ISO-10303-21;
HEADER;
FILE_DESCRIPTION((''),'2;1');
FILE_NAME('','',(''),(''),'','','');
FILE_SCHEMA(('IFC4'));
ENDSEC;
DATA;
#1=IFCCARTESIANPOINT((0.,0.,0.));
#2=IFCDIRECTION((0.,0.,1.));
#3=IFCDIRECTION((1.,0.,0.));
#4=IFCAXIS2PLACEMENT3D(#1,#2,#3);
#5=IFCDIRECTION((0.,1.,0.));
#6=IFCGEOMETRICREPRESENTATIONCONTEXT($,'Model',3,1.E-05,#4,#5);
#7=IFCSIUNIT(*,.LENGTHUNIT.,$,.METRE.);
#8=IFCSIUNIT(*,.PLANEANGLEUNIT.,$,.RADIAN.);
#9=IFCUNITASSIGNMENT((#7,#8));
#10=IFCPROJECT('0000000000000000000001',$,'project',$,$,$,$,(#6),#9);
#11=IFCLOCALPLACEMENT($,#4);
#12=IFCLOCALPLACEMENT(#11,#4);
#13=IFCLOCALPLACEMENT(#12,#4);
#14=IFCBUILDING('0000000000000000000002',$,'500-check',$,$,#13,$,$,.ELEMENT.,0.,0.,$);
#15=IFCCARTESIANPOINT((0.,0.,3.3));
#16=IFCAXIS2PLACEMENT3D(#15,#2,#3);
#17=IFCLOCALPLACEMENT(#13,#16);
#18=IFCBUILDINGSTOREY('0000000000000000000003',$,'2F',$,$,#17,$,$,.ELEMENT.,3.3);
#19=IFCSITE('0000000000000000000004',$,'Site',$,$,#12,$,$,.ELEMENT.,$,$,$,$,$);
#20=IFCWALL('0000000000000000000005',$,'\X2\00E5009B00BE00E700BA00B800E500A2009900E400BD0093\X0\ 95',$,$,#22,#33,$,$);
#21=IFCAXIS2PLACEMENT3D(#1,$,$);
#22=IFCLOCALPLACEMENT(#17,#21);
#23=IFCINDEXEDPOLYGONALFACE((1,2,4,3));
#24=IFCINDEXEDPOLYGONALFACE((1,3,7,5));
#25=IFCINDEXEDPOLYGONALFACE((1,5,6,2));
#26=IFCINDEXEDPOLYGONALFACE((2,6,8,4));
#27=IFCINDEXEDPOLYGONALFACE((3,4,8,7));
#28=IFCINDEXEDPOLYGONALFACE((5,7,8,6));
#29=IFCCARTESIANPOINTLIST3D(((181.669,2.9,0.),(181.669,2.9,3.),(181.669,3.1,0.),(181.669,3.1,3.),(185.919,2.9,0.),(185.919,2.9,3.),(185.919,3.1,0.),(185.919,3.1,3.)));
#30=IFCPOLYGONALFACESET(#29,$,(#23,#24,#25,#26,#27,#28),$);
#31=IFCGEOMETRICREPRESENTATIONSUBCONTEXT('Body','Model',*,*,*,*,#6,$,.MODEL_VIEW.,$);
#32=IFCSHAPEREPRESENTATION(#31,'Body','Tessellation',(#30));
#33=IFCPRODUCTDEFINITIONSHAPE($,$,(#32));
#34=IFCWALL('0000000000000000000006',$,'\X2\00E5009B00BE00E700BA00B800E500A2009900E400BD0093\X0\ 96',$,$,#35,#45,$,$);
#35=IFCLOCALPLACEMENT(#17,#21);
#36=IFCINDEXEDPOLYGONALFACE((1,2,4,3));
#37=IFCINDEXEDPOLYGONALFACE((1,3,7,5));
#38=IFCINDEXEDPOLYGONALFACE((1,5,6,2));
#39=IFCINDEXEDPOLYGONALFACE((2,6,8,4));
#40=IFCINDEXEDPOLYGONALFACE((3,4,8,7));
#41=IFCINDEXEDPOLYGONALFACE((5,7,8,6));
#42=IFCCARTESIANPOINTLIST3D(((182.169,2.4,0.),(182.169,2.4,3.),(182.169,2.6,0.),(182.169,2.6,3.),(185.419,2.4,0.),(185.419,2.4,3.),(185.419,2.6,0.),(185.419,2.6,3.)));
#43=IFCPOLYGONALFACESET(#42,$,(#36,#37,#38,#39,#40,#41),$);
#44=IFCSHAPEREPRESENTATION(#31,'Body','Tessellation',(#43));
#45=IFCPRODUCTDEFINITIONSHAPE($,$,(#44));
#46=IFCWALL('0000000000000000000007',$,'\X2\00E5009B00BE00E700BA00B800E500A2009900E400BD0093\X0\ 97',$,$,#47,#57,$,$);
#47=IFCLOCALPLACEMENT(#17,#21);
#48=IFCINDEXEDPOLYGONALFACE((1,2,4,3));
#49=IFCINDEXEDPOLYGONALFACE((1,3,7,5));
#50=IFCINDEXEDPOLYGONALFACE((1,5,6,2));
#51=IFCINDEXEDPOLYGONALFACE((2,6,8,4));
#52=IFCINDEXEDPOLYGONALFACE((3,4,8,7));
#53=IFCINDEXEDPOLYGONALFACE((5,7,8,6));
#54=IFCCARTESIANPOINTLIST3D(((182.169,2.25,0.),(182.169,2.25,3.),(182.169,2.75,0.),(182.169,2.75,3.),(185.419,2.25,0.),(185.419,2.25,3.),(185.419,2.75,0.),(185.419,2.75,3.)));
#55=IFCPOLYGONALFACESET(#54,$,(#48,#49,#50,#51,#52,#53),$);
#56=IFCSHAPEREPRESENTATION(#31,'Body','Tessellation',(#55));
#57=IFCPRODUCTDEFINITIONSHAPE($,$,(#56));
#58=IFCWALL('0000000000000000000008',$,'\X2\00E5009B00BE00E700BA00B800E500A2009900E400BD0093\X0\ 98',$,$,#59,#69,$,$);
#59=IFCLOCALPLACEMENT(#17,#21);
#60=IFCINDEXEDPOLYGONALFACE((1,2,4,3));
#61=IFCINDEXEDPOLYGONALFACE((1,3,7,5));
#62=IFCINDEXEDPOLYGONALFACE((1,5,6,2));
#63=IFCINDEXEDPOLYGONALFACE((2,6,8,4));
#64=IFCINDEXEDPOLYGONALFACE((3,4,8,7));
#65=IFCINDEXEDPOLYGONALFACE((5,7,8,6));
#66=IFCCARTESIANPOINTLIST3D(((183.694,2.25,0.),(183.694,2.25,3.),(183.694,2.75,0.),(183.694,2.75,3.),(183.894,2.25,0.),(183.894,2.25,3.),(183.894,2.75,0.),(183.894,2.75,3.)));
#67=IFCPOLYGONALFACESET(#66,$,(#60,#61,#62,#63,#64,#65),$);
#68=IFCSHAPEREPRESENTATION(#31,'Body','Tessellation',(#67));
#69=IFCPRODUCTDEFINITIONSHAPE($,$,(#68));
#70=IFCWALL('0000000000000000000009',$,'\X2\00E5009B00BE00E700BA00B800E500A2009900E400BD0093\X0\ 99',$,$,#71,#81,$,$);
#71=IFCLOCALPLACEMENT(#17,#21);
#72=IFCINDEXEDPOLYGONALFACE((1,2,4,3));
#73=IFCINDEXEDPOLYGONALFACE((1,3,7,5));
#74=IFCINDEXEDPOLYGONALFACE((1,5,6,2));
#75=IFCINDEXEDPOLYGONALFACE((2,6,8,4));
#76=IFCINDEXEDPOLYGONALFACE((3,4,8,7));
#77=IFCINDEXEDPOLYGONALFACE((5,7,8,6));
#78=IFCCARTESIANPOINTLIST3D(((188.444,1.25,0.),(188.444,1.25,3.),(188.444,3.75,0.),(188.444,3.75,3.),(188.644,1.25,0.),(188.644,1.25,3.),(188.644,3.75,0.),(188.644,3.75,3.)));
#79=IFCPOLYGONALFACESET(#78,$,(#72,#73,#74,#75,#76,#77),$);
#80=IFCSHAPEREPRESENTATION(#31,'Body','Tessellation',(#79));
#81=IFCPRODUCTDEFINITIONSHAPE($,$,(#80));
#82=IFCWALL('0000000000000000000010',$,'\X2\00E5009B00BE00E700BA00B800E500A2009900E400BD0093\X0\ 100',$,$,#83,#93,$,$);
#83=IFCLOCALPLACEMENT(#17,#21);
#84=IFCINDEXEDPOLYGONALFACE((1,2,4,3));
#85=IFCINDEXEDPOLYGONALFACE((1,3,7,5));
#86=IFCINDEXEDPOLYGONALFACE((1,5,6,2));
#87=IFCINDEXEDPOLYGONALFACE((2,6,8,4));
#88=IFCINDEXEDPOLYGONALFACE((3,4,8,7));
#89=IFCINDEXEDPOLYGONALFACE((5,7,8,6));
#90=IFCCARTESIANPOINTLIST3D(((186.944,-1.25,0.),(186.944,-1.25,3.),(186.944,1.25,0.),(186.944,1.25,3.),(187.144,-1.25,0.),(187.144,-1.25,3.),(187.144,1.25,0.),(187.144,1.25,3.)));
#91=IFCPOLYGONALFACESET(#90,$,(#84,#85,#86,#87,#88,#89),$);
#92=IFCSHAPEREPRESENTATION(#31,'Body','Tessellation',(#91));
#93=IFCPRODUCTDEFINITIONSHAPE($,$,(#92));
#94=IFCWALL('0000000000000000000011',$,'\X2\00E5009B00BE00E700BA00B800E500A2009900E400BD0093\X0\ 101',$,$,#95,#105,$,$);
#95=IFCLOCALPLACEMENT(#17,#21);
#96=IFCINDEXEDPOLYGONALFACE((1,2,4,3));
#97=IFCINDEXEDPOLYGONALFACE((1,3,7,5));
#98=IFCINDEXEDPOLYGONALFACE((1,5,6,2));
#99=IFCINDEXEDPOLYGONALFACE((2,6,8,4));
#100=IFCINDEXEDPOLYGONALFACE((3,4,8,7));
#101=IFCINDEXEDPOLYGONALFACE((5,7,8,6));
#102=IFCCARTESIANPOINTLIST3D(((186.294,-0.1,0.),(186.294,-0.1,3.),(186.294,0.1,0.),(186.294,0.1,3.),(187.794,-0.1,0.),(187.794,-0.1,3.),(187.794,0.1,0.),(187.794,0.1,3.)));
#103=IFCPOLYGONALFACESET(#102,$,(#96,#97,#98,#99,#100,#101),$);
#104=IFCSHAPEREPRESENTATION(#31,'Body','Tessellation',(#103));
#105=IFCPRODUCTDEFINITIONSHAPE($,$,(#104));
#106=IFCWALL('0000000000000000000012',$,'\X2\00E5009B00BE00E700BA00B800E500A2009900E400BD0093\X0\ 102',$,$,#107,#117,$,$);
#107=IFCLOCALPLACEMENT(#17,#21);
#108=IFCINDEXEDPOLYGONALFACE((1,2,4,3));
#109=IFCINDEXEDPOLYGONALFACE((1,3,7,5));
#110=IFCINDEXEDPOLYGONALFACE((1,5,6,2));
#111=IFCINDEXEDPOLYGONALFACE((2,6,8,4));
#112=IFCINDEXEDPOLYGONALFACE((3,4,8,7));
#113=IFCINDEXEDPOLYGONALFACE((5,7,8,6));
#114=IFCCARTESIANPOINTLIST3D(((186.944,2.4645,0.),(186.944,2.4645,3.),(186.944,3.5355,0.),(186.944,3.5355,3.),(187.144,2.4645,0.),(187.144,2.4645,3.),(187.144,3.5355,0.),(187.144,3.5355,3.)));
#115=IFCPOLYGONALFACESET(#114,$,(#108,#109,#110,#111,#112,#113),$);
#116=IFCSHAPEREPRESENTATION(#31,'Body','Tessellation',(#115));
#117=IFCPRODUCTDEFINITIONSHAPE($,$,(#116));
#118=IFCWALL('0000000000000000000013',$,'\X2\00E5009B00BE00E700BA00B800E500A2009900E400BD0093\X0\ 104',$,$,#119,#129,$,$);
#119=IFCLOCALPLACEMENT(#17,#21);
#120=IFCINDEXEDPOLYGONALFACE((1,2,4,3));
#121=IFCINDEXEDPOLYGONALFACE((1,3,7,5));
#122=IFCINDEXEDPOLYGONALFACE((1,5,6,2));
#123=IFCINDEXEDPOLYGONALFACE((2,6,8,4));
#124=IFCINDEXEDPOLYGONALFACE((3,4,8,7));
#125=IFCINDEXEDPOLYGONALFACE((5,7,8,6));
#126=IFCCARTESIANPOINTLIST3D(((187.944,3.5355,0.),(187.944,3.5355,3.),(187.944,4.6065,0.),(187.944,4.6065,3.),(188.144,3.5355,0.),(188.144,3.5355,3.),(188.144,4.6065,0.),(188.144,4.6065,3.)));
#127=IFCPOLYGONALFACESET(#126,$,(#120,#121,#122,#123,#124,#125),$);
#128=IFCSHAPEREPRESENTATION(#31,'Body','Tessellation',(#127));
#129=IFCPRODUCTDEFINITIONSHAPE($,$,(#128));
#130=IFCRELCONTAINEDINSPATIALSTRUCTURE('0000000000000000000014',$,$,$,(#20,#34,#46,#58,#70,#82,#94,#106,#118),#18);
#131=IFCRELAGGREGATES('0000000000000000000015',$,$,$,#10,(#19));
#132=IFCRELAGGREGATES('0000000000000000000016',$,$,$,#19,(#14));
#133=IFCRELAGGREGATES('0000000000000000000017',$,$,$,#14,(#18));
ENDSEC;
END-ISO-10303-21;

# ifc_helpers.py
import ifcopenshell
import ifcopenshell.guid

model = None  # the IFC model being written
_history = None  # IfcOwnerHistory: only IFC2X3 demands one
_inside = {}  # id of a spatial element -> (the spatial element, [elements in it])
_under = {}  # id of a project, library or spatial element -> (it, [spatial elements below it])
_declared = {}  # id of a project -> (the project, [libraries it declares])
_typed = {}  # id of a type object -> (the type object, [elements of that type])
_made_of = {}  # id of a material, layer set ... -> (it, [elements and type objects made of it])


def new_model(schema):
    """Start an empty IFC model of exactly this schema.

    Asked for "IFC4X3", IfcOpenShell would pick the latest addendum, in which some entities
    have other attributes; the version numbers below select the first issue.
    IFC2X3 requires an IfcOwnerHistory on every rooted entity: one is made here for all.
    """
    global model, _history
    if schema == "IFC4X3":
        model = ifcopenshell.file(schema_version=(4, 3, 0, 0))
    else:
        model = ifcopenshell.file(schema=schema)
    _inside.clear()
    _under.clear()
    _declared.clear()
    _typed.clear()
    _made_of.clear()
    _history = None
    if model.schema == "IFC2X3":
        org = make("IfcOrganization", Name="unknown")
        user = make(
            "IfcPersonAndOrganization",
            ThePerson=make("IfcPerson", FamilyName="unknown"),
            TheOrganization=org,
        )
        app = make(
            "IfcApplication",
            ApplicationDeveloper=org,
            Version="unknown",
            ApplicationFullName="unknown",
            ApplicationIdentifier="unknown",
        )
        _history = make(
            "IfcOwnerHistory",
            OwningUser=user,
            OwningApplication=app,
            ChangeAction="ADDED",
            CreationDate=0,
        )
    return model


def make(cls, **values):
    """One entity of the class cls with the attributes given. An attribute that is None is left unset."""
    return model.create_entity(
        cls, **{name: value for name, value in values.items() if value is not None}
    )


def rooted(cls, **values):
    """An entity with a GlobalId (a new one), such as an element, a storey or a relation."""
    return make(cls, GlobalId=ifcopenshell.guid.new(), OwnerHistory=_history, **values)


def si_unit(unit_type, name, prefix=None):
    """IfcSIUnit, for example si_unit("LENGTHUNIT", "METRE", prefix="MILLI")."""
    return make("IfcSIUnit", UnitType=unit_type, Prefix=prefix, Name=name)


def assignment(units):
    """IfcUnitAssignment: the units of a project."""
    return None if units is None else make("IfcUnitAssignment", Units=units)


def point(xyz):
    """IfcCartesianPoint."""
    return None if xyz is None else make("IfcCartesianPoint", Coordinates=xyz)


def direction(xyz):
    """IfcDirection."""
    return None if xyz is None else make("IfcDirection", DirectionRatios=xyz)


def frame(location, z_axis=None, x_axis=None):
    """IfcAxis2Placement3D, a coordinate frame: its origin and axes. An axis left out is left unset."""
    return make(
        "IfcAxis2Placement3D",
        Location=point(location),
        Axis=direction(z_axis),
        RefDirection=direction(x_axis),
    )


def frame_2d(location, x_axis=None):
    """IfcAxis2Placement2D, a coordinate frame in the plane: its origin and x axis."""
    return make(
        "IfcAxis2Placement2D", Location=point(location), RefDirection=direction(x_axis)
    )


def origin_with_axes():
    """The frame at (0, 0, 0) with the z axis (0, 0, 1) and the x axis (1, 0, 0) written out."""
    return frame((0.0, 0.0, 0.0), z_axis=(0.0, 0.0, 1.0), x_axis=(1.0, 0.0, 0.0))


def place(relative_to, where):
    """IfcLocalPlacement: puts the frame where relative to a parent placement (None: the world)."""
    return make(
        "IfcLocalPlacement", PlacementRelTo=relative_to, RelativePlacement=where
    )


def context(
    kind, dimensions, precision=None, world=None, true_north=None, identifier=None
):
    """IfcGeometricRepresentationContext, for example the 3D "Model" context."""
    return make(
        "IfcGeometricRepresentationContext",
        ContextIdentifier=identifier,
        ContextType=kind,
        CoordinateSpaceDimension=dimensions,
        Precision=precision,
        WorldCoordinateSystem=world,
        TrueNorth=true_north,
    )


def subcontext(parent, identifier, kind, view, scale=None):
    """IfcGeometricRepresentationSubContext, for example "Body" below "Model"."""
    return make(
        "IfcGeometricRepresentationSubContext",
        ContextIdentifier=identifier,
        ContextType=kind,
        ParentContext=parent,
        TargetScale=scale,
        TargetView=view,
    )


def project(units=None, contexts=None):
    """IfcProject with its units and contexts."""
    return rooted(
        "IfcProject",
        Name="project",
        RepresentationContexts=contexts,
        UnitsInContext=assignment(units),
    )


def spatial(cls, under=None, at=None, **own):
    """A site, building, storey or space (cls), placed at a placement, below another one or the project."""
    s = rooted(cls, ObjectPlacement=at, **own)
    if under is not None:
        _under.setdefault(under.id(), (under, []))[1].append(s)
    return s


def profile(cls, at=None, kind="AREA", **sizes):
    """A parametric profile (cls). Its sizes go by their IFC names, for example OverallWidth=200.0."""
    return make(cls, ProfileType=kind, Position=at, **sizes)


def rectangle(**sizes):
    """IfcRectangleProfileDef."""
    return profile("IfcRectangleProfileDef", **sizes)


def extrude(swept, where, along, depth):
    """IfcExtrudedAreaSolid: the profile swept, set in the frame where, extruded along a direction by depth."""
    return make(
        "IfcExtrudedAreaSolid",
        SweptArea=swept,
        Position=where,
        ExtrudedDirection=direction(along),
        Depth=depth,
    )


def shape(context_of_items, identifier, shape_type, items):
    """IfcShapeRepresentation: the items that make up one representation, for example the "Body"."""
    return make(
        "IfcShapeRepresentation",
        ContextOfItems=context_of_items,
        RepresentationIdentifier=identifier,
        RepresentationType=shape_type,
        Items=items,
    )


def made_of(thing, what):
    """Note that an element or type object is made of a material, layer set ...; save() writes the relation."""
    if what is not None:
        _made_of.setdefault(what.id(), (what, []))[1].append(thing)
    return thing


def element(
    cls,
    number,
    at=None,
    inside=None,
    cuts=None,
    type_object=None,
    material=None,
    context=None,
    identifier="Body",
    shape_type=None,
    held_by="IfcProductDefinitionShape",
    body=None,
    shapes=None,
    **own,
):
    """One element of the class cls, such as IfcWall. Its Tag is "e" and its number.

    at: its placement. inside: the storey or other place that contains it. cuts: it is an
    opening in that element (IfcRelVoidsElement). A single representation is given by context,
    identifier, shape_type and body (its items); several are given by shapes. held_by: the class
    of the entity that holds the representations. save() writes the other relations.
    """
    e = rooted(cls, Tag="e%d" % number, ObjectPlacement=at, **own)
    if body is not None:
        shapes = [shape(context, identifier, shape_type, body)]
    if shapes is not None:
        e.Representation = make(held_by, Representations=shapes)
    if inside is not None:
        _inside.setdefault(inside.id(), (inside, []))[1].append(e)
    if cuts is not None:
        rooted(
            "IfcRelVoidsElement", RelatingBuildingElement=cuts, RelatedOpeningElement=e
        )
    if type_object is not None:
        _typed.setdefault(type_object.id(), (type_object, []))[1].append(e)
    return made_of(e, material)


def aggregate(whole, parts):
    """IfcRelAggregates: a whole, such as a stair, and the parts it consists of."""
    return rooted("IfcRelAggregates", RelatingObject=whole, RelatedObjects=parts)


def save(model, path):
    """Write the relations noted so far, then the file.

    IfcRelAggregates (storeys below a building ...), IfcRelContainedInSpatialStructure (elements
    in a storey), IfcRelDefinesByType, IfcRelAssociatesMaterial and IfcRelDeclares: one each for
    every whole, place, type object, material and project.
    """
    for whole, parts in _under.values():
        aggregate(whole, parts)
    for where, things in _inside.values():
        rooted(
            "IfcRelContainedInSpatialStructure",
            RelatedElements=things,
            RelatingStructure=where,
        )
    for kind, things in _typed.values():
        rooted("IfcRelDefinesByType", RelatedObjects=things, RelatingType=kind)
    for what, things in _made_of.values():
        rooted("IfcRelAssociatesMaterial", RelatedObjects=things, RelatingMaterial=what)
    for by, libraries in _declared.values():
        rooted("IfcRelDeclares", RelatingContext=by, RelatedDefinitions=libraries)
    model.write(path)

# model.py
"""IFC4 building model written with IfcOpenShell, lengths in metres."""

from ifc_helpers import new_model, si_unit, direction, frame, frame_2d, origin_with_axes, place, context, subcontext, project, spatial, rectangle, extrude, element, save


model = new_model("IFC4")

# Units and contexts
model_context = context("Model", 3, precision=1e-05, world=origin_with_axes(), true_north=direction((0.0, 1.0, 0.0)))
body_context = subcontext(model_context, "Body", "Model", "MODEL_VIEW")
ifc_project = project(units=[si_unit("LENGTHUNIT", "METRE"), si_unit("PLANEANGLEUNIT", "RADIAN")], contexts=[model_context])

# Site, building, storey
placement = place(None, origin_with_axes())
site_placement = place(placement, origin_with_axes())
site = spatial("IfcSite", under=ifc_project, at=site_placement, Name="Site", CompositionType="ELEMENT")
building_placement = place(site_placement, origin_with_axes())
building = spatial("IfcBuilding", under=site, at=building_placement, Name="500-check", CompositionType="ELEMENT", ElevationOfRefHeight=0.0, ElevationOfTerrain=0.0)
storey_placement = place(building_placement, frame((0.0, 0.0, 3.3), z_axis=(0.0, 0.0, 1.0), x_axis=(1.0, 0.0, 0.0)))
storey = spatial("IfcBuildingStorey", under=building, at=storey_placement, Name="2F", CompositionType="ELEMENT", Elevation=3.3)

# Walls
wall_1_placement = place(storey_placement, frame((183.794, 3.0, 0.0), z_axis=(0.0, 0.0, 1.0), x_axis=(1.0, 0.0, 0.0)))
element("IfcWall", 1, at=wall_1_placement, inside=storey, Name="å\u009b¾çº¸å¢\u0099ä½\u0093 95", context=body_context, shape_type="SweptSolid", body=[
    extrude(rectangle(XDim=4.25, YDim=0.2, at=frame_2d((0.0, 0.0), x_axis=(1.0, 0.0, 0.0))), frame((0.0, 0.0, 0.0), z_axis=(0.0, 0.0, 1.0)), (0.0, 0.0, 1.0), 3.0),
])
wall_2_placement = place(storey_placement, frame((183.794, 2.5, 0.0), z_axis=(0.0, 0.0, 1.0), x_axis=(1.0, 0.0, 0.0)))
element("IfcWall", 2, at=wall_2_placement, inside=storey, Name="å\u009b¾çº¸å¢\u0099ä½\u0093 96", context=body_context, shape_type="SweptSolid", body=[
    extrude(rectangle(XDim=3.25, YDim=0.2, at=frame_2d((0.0, 0.0), x_axis=(1.0, 0.0, 0.0))), frame((0.0, 0.0, 0.0), z_axis=(0.0, 0.0, 1.0)), (0.0, 0.0, 1.0), 3.0),
])
wall_3_placement = place(storey_placement, frame((183.794, 2.5, 0.0), z_axis=(0.0, 0.0, 1.0), x_axis=(1.0, 0.0, 0.0)))
element("IfcWall", 3, at=wall_3_placement, inside=storey, Name="å\u009b¾çº¸å¢\u0099ä½\u0093 97", context=body_context, shape_type="SweptSolid", body=[
    extrude(rectangle(XDim=3.25, YDim=0.5, at=frame_2d((0.0, 0.0), x_axis=(1.0, 0.0, 0.0))), frame((0.0, 0.0, 0.0), z_axis=(0.0, 0.0, 1.0)), (0.0, 0.0, 1.0), 3.0),
])
wall_4_placement = place(storey_placement, frame((183.794, 2.5, 0.0), z_axis=(0.0, 0.0, 1.0), x_axis=(0.0, 1.0, 0.0)))
element("IfcWall", 4, at=wall_4_placement, inside=storey, Name="å\u009b¾çº¸å¢\u0099ä½\u0093 98", context=body_context, shape_type="SweptSolid", body=[
    extrude(rectangle(XDim=0.5, YDim=0.2, at=frame_2d((0.0, 0.0), x_axis=(1.0, 0.0, 0.0))), frame((0.0, 0.0, 0.0), z_axis=(0.0, 0.0, 1.0)), (0.0, 0.0, 1.0), 3.0),
])
for number, where, z_axis, x_axis, name in (
    (5, (188.544, 2.5, 0.0), (0.0, 0.0, 1.0), (0.0, -1.0, 0.0), "å\u009b¾çº¸å¢\u0099ä½\u0093 99"),
    (6, (187.044, 0.0, 0.0), (0.0, 0.0, 1.0), (0.0, 1.0, 0.0), "å\u009b¾çº¸å¢\u0099ä½\u0093 100"),
):
    element("IfcWall", number, at=place(storey_placement, frame(where, z_axis=z_axis, x_axis=x_axis)), inside=storey, Name=name, context=body_context, shape_type="SweptSolid", body=[
        extrude(rectangle(XDim=2.5, YDim=0.2, at=frame_2d((0.0, 0.0), x_axis=(1.0, 0.0, 0.0))), frame((0.0, 0.0, 0.0), z_axis=(0.0, 0.0, 1.0)), (0.0, 0.0, 1.0), 3.0),
    ])
wall_5_placement = place(storey_placement, frame((187.044, 0.0, 0.0), z_axis=(0.0, 0.0, 1.0), x_axis=(1.0, 0.0, 0.0)))
element("IfcWall", 7, at=wall_5_placement, inside=storey, Name="å\u009b¾çº¸å¢\u0099ä½\u0093 101", context=body_context, shape_type="SweptSolid", body=[
    extrude(rectangle(XDim=1.5, YDim=0.2, at=frame_2d((0.0, 0.0), x_axis=(1.0, 0.0, 0.0))), frame((0.0, 0.0, 0.0), z_axis=(0.0, 0.0, 1.0)), (0.0, 0.0, 1.0), 3.0),
])
wall_6_placement = place(storey_placement, frame((187.044, 3.0, 0.0), z_axis=(0.0, 0.0, 1.0), x_axis=(0.0, 1.0, 0.0)))
element("IfcWall", 8, at=wall_6_placement, inside=storey, Name="å\u009b¾çº¸å¢\u0099ä½\u0093 102", context=body_context, shape_type="SweptSolid", body=[
    extrude(rectangle(XDim=1.071, YDim=0.2, at=frame_2d((0.0, 0.0), x_axis=(1.0, 0.0, 0.0))), frame((0.0, 0.0, 0.0), z_axis=(0.0, 0.0, 1.0)), (0.0, 0.0, 1.0), 3.0),
])
wall_7_placement = place(storey_placement, frame((188.044, 4.071, 0.0), z_axis=(0.0, 0.0, 1.0), x_axis=(0.0, -1.0, 0.0)))
element("IfcWall", 9, at=wall_7_placement, inside=storey, Name="å\u009b¾çº¸å¢\u0099ä½\u0093 104", context=body_context, shape_type="SweptSolid", body=[
    extrude(rectangle(XDim=1.071, YDim=0.2, at=frame_2d((0.0, 0.0), x_axis=(1.0, 0.0, 0.0))), frame((0.0, 0.0, 0.0), z_axis=(0.0, 0.0, 1.0)), (0.0, 0.0, 1.0), 3.0),
])

save(model, "model.ifc")
